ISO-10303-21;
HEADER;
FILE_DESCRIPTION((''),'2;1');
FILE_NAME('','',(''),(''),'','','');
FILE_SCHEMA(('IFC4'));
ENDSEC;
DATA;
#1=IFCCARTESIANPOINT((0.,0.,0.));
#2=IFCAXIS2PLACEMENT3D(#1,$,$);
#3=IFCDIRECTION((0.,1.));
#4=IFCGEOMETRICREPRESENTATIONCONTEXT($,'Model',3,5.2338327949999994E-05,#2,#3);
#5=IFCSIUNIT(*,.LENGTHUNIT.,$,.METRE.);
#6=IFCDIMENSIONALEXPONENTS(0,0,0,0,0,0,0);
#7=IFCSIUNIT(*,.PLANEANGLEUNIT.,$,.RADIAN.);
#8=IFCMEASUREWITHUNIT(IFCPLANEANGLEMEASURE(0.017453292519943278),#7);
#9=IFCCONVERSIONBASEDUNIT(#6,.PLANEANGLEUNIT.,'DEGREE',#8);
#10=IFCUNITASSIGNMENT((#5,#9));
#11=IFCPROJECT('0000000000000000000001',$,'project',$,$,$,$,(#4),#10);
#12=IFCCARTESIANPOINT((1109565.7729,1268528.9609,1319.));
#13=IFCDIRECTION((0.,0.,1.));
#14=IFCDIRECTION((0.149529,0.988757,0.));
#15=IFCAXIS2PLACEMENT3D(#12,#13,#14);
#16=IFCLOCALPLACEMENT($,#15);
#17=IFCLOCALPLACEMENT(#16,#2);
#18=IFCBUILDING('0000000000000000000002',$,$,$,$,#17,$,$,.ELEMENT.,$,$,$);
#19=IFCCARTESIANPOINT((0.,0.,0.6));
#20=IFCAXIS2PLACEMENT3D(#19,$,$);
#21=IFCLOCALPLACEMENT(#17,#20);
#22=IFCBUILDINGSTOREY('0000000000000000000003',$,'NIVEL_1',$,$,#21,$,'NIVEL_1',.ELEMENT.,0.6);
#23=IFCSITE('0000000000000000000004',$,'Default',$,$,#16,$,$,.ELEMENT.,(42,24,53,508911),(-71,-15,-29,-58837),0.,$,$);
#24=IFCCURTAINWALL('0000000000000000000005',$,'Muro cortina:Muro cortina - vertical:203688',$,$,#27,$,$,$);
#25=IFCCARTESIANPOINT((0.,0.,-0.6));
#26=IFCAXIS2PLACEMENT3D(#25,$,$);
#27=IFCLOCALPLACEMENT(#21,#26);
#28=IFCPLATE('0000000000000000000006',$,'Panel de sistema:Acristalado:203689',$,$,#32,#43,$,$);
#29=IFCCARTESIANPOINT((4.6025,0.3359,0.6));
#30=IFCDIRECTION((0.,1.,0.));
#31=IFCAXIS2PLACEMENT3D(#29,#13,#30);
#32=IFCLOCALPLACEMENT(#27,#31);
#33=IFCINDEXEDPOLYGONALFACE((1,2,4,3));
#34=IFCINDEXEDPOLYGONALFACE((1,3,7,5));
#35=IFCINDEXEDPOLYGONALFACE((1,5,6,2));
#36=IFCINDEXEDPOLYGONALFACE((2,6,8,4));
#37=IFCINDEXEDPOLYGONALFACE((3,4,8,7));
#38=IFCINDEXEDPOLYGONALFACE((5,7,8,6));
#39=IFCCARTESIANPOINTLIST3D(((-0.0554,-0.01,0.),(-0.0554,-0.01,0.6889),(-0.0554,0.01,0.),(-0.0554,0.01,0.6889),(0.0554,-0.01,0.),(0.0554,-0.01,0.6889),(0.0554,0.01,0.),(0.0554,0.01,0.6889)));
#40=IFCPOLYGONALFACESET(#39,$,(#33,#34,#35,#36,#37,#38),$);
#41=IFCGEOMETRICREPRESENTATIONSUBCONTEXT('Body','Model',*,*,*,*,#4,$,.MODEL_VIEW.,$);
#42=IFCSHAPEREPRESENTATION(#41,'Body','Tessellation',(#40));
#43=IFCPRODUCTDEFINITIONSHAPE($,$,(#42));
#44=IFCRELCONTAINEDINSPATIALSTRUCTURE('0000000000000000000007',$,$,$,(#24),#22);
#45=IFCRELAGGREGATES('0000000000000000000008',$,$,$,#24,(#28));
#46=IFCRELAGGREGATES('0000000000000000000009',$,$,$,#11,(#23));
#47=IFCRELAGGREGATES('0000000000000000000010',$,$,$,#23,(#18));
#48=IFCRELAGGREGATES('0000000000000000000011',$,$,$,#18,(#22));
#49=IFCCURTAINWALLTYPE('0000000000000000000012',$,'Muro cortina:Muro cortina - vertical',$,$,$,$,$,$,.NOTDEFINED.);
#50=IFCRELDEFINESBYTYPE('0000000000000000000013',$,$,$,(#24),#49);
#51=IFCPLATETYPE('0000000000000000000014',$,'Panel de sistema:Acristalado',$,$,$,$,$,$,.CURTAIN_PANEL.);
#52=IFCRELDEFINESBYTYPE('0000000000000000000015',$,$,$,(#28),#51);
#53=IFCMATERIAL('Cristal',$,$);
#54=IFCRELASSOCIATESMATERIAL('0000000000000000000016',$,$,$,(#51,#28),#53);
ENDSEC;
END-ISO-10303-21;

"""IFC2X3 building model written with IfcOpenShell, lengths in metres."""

from ifc_helpers import new_model, entity, si_unit, converted_unit, direction, frame, origin, origin_2d_with_axis, place, context, subcontext, project, spatial, rectangle, extrude, source, transform, mapped, material, type_object, type_shapes, element, aggregate, save


model = new_model("IFC2X3")

# Units and contexts
model_context = context("Model", 3, precision=5.2338327949999994e-05, world=origin(), true_north=direction((0.0, 1.0)))
body_context = subcontext(model_context, "Body", "Model", "MODEL_VIEW")
ifc_project = project(units=[si_unit("LENGTHUNIT", "METRE"), converted_unit("PLANEANGLEUNIT", "DEGREE", entity("IfcPlaneAngleMeasure", 0.017453292519943278), si_unit("PLANEANGLEUNIT", "RADIAN"), dimensions=[0, 0, 0, 0, 0, 0, 0])], contexts=[model_context])

# Site, building, storey
site_placement = place(None, frame((1109565.7729, 1268528.9609, 1319.0), z_axis=(0.0, 0.0, 1.0), x_axis=(0.149529, 0.988757, 0.0)))
site = spatial("IfcSite", under=ifc_project, at=site_placement, Name="Default", CompositionType="ELEMENT", RefLatitude=(42, 24, 53, 508911), RefLongitude=(-71, -15, -29, -58837), RefElevation=0.0)
building_placement = place(site_placement, origin())
building = spatial("IfcBuilding", under=site, at=building_placement, CompositionType="ELEMENT")
storey_placement = place(building_placement, frame((0.0, 0.0, 0.6)))
storey = spatial("IfcBuildingStorey", under=building, at=storey_placement, Name="NIVEL_1", LongName="NIVEL_1", CompositionType="ELEMENT", Elevation=0.6)

# Shared definitions
curtain_wall_type = type_object("IfcCurtainWallType", Name="Muro cortina:Muro cortina - vertical", PredefinedType="NOTDEFINED")
ifc_material_1 = material(Name="Cristal")

# Curtain wall, plate
curtain_wall_1_placement = place(storey_placement, frame((0.0, 0.0, -0.6)))
curtain_wall_1 = element("IfcCurtainWall", 1, at=curtain_wall_1_placement, inside=storey, type_object=curtain_wall_type, Name="Muro cortina:Muro cortina - vertical:203688")
plate_type_1 = type_object("IfcPlateType", Name="Panel de sistema:Acristalado", PredefinedType="CURTAIN_PANEL", material=ifc_material_1)
shared_shape_1 = source(origin(), body_context, "Body", "SweptSolid", [
    extrude(rectangle(XDim=0.02, YDim=0.1108, at=origin_2d_with_axis()), frame((0.0, 0.0, 0.0), z_axis=(0.0, 0.0, 1.0), x_axis=(0.0, 1.0, 0.0)), (0.0, 0.0, 1.0), 0.6889),
])
type_shapes(plate_type_1, [shared_shape_1])
plate_1_placement = place(curtain_wall_1_placement, frame((4.6025, 0.3359, 0.6), z_axis=(0.0, 0.0, 1.0), x_axis=(0.0, 1.0, 0.0)))
plate_1 = element("IfcPlate", 2, at=plate_1_placement, type_object=plate_type_1, material=ifc_material_1, Name="Panel de sistema:Acristalado:203689", context=body_context, shape_type="MappedRepresentation", body=[
    mapped(shared_shape_1, transform((0.0, 0.0, 0.0), scale=1.0)),
])
aggregate(curtain_wall_1, [plate_1])

save(model, "model.ifc")
